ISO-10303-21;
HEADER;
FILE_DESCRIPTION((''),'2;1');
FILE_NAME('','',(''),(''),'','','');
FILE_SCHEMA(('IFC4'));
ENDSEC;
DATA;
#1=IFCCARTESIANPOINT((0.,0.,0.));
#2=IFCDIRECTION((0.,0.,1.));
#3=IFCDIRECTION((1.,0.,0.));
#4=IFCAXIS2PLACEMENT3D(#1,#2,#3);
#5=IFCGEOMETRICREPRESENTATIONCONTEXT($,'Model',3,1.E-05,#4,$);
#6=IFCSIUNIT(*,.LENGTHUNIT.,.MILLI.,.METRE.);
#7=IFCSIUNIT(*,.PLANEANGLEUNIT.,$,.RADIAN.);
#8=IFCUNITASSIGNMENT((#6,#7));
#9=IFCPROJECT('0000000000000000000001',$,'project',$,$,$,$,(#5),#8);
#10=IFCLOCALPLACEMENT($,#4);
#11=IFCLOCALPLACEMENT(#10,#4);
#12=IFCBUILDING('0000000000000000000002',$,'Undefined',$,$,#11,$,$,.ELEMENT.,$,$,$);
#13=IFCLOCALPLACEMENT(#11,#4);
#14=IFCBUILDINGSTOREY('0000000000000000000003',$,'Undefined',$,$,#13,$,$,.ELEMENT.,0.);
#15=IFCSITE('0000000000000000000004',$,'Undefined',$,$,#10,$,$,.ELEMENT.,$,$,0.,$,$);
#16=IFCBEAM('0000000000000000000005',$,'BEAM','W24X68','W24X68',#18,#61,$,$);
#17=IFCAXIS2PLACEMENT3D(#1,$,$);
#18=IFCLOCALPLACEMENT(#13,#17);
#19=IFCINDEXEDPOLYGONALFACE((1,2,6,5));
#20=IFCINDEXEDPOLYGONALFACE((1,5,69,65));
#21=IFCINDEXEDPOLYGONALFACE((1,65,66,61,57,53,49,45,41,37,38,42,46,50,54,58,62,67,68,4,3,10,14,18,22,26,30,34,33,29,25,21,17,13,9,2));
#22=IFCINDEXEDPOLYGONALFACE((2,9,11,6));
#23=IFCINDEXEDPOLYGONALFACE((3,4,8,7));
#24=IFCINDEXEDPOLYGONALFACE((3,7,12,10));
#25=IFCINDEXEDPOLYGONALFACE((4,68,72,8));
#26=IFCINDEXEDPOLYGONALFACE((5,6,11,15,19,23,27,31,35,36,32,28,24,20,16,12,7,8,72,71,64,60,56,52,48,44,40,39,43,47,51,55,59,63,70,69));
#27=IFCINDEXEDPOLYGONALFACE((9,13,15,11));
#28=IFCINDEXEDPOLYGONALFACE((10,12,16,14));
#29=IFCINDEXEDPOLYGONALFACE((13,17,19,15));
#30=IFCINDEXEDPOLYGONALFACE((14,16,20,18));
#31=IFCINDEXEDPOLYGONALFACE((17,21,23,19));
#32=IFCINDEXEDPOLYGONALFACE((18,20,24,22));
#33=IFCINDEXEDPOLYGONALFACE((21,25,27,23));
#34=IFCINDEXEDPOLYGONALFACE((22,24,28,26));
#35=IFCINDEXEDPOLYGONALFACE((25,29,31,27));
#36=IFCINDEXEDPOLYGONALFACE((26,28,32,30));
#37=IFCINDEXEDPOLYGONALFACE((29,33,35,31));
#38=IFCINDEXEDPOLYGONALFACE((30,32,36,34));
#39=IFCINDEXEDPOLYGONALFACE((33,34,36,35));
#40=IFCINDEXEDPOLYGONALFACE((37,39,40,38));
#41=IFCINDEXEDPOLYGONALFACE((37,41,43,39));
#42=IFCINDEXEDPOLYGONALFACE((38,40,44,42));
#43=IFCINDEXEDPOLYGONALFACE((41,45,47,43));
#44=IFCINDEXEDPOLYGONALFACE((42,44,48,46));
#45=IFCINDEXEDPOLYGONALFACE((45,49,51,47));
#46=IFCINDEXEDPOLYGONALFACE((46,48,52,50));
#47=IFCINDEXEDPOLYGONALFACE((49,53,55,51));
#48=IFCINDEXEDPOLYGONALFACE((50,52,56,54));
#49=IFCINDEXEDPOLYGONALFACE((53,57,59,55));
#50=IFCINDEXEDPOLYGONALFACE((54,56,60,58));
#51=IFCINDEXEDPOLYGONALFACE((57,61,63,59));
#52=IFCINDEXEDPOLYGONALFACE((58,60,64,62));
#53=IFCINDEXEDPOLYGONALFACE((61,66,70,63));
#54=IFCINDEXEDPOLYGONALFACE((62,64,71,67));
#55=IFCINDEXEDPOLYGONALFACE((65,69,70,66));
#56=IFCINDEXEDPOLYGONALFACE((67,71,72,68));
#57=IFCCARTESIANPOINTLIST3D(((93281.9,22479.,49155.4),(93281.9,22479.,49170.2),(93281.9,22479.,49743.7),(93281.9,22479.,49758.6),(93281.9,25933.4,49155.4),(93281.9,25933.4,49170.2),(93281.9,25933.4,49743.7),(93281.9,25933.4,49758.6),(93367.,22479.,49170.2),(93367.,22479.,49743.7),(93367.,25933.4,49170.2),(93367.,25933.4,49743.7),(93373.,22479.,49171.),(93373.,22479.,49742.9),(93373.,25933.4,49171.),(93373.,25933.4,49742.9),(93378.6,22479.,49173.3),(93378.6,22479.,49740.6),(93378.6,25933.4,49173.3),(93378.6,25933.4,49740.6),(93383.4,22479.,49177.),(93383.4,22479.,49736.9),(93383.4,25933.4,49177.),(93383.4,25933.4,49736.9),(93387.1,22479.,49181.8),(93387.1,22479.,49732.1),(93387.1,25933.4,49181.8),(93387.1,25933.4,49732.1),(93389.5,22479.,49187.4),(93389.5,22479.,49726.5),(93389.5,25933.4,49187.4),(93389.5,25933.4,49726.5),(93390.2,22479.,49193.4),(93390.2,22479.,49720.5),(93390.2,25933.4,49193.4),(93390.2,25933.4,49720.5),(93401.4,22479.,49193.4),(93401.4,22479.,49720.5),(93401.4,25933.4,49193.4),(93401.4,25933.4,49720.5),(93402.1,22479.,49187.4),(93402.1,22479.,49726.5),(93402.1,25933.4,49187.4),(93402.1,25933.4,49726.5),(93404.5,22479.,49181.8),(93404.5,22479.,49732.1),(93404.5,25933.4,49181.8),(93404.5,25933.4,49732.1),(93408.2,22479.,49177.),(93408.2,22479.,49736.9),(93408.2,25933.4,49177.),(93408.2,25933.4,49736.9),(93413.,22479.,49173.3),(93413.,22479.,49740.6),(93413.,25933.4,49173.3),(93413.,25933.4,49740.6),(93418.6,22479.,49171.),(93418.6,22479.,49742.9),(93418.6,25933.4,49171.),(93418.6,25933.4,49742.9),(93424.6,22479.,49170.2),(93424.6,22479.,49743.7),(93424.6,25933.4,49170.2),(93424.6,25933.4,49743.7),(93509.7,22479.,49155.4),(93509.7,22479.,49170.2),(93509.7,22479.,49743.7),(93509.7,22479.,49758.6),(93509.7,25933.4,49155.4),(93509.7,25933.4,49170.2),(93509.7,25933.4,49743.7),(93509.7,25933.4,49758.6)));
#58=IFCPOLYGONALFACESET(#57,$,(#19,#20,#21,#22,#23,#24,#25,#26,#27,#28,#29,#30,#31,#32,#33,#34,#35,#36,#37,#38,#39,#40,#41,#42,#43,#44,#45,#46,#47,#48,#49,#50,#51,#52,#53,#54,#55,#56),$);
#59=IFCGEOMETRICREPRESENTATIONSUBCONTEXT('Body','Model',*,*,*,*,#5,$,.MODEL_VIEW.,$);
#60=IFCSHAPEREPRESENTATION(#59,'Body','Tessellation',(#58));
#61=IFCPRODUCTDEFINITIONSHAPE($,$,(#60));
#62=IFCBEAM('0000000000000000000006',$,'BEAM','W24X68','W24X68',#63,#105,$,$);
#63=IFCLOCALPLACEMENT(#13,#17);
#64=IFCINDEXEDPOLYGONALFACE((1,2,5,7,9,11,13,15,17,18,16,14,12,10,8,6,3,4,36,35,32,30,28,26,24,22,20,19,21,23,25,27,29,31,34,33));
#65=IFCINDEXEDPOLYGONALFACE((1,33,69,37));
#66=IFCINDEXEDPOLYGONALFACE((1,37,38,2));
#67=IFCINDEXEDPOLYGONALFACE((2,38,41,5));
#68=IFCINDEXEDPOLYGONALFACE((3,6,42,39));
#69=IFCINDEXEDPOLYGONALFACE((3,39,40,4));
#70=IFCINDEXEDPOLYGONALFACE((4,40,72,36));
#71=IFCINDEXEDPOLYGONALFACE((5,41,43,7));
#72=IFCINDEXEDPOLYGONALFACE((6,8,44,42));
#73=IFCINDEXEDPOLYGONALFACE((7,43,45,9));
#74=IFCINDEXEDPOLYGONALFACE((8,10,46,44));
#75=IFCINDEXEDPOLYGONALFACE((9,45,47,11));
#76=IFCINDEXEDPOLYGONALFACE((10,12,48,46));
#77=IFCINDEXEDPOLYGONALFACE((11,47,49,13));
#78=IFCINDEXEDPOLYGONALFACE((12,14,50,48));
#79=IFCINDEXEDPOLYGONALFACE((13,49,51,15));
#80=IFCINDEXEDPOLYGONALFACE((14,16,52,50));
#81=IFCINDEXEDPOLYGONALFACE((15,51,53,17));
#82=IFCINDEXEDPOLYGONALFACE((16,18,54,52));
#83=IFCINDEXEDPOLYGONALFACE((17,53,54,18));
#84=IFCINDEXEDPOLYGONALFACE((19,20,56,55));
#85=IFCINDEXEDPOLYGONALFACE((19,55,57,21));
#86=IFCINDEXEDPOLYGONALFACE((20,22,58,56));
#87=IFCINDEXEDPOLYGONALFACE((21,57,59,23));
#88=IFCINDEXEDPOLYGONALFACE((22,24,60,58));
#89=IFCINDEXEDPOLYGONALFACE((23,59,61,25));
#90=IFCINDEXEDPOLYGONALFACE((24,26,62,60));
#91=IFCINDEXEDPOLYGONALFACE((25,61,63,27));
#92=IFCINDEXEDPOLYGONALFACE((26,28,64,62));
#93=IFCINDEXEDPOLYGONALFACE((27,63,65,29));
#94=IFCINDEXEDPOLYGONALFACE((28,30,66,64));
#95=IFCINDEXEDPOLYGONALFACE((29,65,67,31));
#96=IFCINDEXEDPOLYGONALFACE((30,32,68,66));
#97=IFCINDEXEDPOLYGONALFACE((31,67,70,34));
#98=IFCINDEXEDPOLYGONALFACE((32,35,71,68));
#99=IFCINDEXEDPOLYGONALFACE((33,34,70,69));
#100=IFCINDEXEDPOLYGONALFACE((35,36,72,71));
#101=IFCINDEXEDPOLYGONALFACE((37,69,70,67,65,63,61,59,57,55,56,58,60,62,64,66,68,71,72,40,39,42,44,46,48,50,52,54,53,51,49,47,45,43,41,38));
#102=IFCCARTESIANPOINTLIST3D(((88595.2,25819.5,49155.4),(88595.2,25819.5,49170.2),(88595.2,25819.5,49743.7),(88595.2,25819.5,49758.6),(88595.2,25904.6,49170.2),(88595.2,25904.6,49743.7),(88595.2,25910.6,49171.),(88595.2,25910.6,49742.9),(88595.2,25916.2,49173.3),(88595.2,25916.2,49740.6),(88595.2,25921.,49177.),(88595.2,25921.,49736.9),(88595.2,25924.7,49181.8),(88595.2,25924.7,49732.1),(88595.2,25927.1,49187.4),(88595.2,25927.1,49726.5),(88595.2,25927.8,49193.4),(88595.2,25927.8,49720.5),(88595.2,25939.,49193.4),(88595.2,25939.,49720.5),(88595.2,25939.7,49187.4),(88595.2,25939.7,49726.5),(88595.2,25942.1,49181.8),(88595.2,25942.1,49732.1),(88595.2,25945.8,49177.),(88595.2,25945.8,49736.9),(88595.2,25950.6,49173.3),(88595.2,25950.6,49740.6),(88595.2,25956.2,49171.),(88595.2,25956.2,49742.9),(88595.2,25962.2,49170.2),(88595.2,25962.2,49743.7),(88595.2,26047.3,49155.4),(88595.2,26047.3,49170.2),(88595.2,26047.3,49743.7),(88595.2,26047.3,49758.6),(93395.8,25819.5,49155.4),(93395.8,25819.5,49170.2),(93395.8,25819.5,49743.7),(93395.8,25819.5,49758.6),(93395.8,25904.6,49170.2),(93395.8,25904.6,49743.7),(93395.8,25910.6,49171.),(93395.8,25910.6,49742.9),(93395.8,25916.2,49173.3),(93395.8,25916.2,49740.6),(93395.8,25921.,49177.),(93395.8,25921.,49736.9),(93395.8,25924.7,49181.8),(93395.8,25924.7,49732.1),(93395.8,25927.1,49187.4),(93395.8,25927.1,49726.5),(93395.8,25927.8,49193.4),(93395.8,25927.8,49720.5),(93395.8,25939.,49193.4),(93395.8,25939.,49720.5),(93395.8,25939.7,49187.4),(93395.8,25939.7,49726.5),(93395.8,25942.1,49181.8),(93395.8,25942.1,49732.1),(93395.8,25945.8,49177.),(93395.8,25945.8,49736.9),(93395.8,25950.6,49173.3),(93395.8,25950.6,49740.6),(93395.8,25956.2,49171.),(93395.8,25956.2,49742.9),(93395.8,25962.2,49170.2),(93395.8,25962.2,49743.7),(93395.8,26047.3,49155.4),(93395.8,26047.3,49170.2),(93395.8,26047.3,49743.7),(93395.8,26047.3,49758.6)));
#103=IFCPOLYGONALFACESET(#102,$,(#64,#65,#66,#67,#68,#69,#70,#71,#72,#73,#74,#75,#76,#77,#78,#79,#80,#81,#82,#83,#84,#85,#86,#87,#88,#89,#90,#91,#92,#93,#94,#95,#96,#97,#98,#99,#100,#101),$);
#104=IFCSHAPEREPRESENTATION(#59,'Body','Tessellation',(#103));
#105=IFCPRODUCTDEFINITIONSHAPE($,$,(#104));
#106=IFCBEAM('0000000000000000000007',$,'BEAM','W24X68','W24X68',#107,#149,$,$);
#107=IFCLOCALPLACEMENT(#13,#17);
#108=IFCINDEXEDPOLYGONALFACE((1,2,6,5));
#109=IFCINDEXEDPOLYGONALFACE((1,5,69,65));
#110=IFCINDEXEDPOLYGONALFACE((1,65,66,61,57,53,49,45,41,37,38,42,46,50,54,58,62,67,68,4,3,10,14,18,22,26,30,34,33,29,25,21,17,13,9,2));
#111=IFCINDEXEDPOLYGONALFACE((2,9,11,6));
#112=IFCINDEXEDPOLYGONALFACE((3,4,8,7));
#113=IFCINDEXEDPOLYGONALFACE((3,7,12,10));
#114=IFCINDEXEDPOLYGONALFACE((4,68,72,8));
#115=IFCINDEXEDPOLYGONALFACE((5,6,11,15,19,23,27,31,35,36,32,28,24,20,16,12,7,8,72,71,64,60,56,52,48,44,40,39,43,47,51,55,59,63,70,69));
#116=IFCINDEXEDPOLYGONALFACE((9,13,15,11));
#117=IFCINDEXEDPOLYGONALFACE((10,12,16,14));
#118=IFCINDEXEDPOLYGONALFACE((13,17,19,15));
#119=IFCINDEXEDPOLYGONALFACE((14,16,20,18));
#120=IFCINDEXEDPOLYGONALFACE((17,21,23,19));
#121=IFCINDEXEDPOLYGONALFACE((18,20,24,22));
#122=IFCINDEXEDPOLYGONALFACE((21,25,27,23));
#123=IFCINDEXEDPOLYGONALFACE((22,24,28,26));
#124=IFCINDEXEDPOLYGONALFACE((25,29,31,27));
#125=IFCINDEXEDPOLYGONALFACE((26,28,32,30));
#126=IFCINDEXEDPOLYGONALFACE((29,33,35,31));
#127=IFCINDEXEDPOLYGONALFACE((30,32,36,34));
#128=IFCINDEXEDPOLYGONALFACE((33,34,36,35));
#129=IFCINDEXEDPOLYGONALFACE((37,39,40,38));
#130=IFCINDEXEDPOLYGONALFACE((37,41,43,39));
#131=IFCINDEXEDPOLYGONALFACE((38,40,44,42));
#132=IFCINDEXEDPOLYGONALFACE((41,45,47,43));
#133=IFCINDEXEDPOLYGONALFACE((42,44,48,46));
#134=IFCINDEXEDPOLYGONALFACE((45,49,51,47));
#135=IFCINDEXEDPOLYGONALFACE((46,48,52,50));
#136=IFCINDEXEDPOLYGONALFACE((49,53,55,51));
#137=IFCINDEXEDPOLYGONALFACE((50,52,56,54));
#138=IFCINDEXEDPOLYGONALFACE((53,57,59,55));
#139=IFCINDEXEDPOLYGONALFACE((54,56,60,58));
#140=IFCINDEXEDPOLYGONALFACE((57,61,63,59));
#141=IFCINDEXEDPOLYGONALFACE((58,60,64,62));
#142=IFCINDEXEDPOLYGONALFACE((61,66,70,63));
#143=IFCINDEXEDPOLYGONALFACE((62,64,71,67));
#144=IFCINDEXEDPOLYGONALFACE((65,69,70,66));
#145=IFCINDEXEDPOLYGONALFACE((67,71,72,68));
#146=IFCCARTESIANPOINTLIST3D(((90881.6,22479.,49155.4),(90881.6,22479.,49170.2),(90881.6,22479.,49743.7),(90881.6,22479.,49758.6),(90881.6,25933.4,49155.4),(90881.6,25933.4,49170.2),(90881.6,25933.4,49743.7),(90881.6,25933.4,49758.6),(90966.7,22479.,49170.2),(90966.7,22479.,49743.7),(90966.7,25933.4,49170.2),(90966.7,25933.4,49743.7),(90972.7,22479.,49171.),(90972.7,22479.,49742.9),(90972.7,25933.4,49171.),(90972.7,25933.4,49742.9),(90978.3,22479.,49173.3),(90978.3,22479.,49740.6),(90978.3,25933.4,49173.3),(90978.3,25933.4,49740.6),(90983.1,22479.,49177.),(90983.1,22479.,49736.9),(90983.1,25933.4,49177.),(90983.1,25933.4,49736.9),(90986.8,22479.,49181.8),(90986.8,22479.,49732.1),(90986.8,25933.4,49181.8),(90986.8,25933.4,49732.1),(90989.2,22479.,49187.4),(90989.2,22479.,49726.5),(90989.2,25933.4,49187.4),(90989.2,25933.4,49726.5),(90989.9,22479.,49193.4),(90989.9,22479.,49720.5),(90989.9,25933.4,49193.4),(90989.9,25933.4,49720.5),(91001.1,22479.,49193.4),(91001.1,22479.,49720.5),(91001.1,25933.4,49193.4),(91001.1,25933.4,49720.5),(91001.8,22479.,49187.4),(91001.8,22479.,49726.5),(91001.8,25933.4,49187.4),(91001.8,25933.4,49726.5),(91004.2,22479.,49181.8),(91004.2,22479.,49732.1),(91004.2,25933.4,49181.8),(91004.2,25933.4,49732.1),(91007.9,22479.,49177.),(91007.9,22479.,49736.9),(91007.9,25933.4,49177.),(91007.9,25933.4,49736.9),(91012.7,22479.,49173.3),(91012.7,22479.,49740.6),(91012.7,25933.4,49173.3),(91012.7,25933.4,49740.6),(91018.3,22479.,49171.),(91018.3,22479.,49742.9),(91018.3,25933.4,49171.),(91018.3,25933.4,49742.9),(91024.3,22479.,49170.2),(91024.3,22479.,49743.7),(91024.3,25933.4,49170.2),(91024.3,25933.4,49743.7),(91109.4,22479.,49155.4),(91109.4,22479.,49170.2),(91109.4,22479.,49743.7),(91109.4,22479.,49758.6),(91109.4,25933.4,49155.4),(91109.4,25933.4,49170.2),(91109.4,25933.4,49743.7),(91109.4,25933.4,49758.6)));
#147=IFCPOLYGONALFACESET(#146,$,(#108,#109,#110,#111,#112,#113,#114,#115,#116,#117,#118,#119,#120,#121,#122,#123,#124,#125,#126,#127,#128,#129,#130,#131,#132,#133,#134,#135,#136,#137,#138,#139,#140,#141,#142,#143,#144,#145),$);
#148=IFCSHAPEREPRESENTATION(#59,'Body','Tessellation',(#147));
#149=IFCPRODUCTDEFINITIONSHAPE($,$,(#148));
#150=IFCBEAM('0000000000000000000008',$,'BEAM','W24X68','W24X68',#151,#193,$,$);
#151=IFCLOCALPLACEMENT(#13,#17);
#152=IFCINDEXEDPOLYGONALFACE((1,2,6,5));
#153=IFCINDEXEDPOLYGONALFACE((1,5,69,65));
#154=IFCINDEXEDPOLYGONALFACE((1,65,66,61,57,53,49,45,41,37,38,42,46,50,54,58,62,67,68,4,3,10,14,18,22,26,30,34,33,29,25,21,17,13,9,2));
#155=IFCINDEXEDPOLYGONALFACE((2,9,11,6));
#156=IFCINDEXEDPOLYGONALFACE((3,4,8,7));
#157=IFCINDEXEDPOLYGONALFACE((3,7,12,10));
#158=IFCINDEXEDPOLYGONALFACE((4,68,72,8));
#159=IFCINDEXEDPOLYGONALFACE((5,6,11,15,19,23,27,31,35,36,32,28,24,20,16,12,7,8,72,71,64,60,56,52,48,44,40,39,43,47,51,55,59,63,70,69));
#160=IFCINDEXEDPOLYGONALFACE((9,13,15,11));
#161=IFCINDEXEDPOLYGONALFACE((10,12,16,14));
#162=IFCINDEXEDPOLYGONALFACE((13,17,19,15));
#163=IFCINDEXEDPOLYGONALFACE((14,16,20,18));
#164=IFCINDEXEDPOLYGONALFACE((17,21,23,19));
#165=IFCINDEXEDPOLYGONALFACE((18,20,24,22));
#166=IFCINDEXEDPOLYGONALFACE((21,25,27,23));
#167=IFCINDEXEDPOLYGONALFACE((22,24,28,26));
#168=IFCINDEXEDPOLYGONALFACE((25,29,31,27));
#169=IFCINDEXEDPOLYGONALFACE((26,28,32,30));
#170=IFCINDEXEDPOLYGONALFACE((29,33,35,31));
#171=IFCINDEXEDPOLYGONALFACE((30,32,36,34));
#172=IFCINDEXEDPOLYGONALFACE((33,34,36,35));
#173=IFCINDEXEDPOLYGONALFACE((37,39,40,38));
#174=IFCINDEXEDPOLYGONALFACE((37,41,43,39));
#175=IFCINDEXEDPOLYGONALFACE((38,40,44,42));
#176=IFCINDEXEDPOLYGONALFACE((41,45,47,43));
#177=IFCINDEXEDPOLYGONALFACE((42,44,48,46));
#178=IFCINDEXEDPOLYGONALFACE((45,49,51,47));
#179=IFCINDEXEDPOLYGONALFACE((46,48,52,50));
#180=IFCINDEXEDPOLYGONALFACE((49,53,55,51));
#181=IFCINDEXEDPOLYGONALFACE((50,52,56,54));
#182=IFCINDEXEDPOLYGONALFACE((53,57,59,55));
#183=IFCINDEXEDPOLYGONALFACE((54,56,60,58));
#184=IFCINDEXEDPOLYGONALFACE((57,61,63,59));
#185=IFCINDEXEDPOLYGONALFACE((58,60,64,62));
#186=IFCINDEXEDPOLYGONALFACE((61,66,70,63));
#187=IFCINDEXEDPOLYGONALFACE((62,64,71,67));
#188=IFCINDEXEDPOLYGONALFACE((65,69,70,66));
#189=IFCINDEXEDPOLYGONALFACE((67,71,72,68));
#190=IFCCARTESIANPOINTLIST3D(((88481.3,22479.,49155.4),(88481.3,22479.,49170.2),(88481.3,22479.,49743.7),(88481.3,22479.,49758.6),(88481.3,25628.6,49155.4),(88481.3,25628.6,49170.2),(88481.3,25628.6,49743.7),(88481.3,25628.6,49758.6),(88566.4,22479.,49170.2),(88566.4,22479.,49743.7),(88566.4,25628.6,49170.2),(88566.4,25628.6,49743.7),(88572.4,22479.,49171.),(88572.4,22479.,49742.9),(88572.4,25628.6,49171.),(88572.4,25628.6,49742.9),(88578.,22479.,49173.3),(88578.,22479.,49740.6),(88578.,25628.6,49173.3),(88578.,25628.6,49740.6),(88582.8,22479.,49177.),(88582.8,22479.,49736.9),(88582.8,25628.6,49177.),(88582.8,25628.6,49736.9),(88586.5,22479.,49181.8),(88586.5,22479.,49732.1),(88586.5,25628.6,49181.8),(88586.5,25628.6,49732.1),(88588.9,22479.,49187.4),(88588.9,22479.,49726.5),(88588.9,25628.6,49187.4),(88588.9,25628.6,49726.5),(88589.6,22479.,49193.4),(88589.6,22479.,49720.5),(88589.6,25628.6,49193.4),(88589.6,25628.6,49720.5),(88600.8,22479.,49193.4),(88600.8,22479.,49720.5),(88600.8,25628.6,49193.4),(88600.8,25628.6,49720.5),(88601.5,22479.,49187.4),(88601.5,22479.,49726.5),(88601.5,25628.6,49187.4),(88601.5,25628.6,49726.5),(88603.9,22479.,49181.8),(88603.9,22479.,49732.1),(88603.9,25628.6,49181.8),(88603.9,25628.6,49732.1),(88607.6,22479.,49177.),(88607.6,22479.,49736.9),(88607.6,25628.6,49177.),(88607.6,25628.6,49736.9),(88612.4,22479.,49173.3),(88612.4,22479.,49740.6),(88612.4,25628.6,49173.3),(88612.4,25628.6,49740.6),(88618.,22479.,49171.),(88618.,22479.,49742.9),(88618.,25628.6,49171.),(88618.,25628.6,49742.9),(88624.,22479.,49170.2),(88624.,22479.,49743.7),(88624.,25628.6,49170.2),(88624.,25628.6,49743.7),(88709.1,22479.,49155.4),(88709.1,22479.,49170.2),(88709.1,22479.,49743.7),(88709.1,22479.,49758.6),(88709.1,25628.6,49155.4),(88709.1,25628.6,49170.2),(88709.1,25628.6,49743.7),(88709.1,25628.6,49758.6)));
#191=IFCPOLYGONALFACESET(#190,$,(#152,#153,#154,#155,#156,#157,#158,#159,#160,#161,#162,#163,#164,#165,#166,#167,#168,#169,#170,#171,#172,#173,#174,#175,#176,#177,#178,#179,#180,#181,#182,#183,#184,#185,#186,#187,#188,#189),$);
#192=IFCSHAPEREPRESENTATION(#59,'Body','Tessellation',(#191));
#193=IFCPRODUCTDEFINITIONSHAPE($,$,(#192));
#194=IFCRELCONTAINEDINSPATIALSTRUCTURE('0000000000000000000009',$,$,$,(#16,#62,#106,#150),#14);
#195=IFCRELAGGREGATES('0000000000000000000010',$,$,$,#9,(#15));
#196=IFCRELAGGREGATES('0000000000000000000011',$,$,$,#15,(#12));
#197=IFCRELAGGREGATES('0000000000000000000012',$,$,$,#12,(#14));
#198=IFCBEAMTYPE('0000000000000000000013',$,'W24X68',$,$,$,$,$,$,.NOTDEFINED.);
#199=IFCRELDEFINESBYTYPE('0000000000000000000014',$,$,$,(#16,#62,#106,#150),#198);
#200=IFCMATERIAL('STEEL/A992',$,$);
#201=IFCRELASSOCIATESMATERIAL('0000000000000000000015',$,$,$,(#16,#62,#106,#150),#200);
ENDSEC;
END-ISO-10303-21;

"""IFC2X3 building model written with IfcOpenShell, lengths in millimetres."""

from ifc_helpers import new_model, si_unit, frame, origin_with_axes, origin_2d_with_axis, place, context, subcontext, project, spatial, i_section, extrude, material, type_object, element, save


model = new_model("IFC2X3")

# Units and contexts
model_context = context("Model", 3, precision=1e-05, world=origin_with_axes())
body_context = subcontext(model_context, "Body", "Model", "MODEL_VIEW")
ifc_project = project(units=[si_unit("LENGTHUNIT", "METRE", prefix="MILLI"), si_unit("PLANEANGLEUNIT", "RADIAN")], contexts=[model_context])

# Site, building, storey
site_placement = place(None, origin_with_axes())
site = spatial("IfcSite", under=ifc_project, at=site_placement, Name="Undefined", CompositionType="ELEMENT", RefElevation=0.0)
building_placement = place(site_placement, origin_with_axes())
building = spatial("IfcBuilding", under=site, at=building_placement, Name="Undefined", CompositionType="ELEMENT")
storey_placement = place(building_placement, origin_with_axes())
storey = spatial("IfcBuildingStorey", under=building, at=storey_placement, Name="Undefined", CompositionType="ELEMENT", Elevation=0.0)

# Shared definitions
ifc_material = material(Name="STEEL/A992")

# Beams
beam_type = type_object("IfcBeamType", Name="W24X68", PredefinedType="NOTDEFINED")
beam_1_placement = place(storey_placement, frame((93395.8, 22479.0, 49457.0), z_axis=(0.0, 0.0, 1.0), x_axis=(0.0, 1.0, 0.0)))
element("IfcBeam", 1, at=beam_1_placement, inside=storey, type_object=beam_type, material=ifc_material, Name="BEAM", Description="W24X68", ObjectType="W24X68", context=body_context, shape_type="SweptSolid", body=[
    extrude(i_section(OverallWidth=227.8, OverallDepth=603.2, WebThickness=11.1, FlangeThickness=14.9, FilletRadius=23.2, at=origin_2d_with_axis()), frame((3454.4, 0.0, 0.0), z_axis=(-1.0, 0.0, 0.0), x_axis=(0.0, -1.0, 0.0)), (0.0, 0.0, 1.0), 3454.4),
])
beam_2_placement = place(storey_placement, frame((88595.2, 25933.4, 49457.0), z_axis=(0.0, 0.0, 1.0), x_axis=(1.0, 0.0, 0.0)))
element("IfcBeam", 2, at=beam_2_placement, inside=storey, type_object=beam_type, material=ifc_material, Name="BEAM", Description="W24X68", ObjectType="W24X68", context=body_context, shape_type="SweptSolid", body=[
    extrude(i_section(OverallWidth=227.8, OverallDepth=603.2, WebThickness=11.1, FlangeThickness=14.9, FilletRadius=23.2, at=origin_2d_with_axis()), frame((4800.6, 0.0, 0.0), z_axis=(-1.0, 0.0, 0.0), x_axis=(0.0, -1.0, 0.0)), (0.0, 0.0, 1.0), 4800.6),
])
beam_3_placement = place(storey_placement, frame((90995.5, 22479.0, 49457.0), z_axis=(0.0, 0.0, 1.0), x_axis=(0.0, 1.0, 0.0)))
element("IfcBeam", 3, at=beam_3_placement, inside=storey, type_object=beam_type, material=ifc_material, Name="BEAM", Description="W24X68", ObjectType="W24X68", context=body_context, shape_type="SweptSolid", body=[
    extrude(i_section(OverallWidth=227.8, OverallDepth=603.2, WebThickness=11.1, FlangeThickness=14.9, FilletRadius=23.2, at=origin_2d_with_axis()), frame((3454.4, 0.0, 0.0), z_axis=(-1.0, 0.0, 0.0), x_axis=(0.0, -1.0, 0.0)), (0.0, 0.0, 1.0), 3454.4),
])
beam_4_placement = place(storey_placement, frame((88595.2, 22479.0, 49457.0), z_axis=(0.0, 0.0, 1.0), x_axis=(0.0, 1.0, 0.0)))
element("IfcBeam", 4, at=beam_4_placement, inside=storey, type_object=beam_type, material=ifc_material, Name="BEAM", Description="W24X68", ObjectType="W24X68", context=body_context, shape_type="SweptSolid", body=[
    extrude(i_section(OverallWidth=227.8, OverallDepth=603.2, WebThickness=11.1, FlangeThickness=14.9, FilletRadius=23.2, at=origin_2d_with_axis()), frame((3149.6, 0.0, 0.0), z_axis=(-1.0, 0.0, 0.0), x_axis=(0.0, -1.0, 0.0)), (0.0, 0.0, 1.0), 3149.6),
])

save(model, "model.ifc")
